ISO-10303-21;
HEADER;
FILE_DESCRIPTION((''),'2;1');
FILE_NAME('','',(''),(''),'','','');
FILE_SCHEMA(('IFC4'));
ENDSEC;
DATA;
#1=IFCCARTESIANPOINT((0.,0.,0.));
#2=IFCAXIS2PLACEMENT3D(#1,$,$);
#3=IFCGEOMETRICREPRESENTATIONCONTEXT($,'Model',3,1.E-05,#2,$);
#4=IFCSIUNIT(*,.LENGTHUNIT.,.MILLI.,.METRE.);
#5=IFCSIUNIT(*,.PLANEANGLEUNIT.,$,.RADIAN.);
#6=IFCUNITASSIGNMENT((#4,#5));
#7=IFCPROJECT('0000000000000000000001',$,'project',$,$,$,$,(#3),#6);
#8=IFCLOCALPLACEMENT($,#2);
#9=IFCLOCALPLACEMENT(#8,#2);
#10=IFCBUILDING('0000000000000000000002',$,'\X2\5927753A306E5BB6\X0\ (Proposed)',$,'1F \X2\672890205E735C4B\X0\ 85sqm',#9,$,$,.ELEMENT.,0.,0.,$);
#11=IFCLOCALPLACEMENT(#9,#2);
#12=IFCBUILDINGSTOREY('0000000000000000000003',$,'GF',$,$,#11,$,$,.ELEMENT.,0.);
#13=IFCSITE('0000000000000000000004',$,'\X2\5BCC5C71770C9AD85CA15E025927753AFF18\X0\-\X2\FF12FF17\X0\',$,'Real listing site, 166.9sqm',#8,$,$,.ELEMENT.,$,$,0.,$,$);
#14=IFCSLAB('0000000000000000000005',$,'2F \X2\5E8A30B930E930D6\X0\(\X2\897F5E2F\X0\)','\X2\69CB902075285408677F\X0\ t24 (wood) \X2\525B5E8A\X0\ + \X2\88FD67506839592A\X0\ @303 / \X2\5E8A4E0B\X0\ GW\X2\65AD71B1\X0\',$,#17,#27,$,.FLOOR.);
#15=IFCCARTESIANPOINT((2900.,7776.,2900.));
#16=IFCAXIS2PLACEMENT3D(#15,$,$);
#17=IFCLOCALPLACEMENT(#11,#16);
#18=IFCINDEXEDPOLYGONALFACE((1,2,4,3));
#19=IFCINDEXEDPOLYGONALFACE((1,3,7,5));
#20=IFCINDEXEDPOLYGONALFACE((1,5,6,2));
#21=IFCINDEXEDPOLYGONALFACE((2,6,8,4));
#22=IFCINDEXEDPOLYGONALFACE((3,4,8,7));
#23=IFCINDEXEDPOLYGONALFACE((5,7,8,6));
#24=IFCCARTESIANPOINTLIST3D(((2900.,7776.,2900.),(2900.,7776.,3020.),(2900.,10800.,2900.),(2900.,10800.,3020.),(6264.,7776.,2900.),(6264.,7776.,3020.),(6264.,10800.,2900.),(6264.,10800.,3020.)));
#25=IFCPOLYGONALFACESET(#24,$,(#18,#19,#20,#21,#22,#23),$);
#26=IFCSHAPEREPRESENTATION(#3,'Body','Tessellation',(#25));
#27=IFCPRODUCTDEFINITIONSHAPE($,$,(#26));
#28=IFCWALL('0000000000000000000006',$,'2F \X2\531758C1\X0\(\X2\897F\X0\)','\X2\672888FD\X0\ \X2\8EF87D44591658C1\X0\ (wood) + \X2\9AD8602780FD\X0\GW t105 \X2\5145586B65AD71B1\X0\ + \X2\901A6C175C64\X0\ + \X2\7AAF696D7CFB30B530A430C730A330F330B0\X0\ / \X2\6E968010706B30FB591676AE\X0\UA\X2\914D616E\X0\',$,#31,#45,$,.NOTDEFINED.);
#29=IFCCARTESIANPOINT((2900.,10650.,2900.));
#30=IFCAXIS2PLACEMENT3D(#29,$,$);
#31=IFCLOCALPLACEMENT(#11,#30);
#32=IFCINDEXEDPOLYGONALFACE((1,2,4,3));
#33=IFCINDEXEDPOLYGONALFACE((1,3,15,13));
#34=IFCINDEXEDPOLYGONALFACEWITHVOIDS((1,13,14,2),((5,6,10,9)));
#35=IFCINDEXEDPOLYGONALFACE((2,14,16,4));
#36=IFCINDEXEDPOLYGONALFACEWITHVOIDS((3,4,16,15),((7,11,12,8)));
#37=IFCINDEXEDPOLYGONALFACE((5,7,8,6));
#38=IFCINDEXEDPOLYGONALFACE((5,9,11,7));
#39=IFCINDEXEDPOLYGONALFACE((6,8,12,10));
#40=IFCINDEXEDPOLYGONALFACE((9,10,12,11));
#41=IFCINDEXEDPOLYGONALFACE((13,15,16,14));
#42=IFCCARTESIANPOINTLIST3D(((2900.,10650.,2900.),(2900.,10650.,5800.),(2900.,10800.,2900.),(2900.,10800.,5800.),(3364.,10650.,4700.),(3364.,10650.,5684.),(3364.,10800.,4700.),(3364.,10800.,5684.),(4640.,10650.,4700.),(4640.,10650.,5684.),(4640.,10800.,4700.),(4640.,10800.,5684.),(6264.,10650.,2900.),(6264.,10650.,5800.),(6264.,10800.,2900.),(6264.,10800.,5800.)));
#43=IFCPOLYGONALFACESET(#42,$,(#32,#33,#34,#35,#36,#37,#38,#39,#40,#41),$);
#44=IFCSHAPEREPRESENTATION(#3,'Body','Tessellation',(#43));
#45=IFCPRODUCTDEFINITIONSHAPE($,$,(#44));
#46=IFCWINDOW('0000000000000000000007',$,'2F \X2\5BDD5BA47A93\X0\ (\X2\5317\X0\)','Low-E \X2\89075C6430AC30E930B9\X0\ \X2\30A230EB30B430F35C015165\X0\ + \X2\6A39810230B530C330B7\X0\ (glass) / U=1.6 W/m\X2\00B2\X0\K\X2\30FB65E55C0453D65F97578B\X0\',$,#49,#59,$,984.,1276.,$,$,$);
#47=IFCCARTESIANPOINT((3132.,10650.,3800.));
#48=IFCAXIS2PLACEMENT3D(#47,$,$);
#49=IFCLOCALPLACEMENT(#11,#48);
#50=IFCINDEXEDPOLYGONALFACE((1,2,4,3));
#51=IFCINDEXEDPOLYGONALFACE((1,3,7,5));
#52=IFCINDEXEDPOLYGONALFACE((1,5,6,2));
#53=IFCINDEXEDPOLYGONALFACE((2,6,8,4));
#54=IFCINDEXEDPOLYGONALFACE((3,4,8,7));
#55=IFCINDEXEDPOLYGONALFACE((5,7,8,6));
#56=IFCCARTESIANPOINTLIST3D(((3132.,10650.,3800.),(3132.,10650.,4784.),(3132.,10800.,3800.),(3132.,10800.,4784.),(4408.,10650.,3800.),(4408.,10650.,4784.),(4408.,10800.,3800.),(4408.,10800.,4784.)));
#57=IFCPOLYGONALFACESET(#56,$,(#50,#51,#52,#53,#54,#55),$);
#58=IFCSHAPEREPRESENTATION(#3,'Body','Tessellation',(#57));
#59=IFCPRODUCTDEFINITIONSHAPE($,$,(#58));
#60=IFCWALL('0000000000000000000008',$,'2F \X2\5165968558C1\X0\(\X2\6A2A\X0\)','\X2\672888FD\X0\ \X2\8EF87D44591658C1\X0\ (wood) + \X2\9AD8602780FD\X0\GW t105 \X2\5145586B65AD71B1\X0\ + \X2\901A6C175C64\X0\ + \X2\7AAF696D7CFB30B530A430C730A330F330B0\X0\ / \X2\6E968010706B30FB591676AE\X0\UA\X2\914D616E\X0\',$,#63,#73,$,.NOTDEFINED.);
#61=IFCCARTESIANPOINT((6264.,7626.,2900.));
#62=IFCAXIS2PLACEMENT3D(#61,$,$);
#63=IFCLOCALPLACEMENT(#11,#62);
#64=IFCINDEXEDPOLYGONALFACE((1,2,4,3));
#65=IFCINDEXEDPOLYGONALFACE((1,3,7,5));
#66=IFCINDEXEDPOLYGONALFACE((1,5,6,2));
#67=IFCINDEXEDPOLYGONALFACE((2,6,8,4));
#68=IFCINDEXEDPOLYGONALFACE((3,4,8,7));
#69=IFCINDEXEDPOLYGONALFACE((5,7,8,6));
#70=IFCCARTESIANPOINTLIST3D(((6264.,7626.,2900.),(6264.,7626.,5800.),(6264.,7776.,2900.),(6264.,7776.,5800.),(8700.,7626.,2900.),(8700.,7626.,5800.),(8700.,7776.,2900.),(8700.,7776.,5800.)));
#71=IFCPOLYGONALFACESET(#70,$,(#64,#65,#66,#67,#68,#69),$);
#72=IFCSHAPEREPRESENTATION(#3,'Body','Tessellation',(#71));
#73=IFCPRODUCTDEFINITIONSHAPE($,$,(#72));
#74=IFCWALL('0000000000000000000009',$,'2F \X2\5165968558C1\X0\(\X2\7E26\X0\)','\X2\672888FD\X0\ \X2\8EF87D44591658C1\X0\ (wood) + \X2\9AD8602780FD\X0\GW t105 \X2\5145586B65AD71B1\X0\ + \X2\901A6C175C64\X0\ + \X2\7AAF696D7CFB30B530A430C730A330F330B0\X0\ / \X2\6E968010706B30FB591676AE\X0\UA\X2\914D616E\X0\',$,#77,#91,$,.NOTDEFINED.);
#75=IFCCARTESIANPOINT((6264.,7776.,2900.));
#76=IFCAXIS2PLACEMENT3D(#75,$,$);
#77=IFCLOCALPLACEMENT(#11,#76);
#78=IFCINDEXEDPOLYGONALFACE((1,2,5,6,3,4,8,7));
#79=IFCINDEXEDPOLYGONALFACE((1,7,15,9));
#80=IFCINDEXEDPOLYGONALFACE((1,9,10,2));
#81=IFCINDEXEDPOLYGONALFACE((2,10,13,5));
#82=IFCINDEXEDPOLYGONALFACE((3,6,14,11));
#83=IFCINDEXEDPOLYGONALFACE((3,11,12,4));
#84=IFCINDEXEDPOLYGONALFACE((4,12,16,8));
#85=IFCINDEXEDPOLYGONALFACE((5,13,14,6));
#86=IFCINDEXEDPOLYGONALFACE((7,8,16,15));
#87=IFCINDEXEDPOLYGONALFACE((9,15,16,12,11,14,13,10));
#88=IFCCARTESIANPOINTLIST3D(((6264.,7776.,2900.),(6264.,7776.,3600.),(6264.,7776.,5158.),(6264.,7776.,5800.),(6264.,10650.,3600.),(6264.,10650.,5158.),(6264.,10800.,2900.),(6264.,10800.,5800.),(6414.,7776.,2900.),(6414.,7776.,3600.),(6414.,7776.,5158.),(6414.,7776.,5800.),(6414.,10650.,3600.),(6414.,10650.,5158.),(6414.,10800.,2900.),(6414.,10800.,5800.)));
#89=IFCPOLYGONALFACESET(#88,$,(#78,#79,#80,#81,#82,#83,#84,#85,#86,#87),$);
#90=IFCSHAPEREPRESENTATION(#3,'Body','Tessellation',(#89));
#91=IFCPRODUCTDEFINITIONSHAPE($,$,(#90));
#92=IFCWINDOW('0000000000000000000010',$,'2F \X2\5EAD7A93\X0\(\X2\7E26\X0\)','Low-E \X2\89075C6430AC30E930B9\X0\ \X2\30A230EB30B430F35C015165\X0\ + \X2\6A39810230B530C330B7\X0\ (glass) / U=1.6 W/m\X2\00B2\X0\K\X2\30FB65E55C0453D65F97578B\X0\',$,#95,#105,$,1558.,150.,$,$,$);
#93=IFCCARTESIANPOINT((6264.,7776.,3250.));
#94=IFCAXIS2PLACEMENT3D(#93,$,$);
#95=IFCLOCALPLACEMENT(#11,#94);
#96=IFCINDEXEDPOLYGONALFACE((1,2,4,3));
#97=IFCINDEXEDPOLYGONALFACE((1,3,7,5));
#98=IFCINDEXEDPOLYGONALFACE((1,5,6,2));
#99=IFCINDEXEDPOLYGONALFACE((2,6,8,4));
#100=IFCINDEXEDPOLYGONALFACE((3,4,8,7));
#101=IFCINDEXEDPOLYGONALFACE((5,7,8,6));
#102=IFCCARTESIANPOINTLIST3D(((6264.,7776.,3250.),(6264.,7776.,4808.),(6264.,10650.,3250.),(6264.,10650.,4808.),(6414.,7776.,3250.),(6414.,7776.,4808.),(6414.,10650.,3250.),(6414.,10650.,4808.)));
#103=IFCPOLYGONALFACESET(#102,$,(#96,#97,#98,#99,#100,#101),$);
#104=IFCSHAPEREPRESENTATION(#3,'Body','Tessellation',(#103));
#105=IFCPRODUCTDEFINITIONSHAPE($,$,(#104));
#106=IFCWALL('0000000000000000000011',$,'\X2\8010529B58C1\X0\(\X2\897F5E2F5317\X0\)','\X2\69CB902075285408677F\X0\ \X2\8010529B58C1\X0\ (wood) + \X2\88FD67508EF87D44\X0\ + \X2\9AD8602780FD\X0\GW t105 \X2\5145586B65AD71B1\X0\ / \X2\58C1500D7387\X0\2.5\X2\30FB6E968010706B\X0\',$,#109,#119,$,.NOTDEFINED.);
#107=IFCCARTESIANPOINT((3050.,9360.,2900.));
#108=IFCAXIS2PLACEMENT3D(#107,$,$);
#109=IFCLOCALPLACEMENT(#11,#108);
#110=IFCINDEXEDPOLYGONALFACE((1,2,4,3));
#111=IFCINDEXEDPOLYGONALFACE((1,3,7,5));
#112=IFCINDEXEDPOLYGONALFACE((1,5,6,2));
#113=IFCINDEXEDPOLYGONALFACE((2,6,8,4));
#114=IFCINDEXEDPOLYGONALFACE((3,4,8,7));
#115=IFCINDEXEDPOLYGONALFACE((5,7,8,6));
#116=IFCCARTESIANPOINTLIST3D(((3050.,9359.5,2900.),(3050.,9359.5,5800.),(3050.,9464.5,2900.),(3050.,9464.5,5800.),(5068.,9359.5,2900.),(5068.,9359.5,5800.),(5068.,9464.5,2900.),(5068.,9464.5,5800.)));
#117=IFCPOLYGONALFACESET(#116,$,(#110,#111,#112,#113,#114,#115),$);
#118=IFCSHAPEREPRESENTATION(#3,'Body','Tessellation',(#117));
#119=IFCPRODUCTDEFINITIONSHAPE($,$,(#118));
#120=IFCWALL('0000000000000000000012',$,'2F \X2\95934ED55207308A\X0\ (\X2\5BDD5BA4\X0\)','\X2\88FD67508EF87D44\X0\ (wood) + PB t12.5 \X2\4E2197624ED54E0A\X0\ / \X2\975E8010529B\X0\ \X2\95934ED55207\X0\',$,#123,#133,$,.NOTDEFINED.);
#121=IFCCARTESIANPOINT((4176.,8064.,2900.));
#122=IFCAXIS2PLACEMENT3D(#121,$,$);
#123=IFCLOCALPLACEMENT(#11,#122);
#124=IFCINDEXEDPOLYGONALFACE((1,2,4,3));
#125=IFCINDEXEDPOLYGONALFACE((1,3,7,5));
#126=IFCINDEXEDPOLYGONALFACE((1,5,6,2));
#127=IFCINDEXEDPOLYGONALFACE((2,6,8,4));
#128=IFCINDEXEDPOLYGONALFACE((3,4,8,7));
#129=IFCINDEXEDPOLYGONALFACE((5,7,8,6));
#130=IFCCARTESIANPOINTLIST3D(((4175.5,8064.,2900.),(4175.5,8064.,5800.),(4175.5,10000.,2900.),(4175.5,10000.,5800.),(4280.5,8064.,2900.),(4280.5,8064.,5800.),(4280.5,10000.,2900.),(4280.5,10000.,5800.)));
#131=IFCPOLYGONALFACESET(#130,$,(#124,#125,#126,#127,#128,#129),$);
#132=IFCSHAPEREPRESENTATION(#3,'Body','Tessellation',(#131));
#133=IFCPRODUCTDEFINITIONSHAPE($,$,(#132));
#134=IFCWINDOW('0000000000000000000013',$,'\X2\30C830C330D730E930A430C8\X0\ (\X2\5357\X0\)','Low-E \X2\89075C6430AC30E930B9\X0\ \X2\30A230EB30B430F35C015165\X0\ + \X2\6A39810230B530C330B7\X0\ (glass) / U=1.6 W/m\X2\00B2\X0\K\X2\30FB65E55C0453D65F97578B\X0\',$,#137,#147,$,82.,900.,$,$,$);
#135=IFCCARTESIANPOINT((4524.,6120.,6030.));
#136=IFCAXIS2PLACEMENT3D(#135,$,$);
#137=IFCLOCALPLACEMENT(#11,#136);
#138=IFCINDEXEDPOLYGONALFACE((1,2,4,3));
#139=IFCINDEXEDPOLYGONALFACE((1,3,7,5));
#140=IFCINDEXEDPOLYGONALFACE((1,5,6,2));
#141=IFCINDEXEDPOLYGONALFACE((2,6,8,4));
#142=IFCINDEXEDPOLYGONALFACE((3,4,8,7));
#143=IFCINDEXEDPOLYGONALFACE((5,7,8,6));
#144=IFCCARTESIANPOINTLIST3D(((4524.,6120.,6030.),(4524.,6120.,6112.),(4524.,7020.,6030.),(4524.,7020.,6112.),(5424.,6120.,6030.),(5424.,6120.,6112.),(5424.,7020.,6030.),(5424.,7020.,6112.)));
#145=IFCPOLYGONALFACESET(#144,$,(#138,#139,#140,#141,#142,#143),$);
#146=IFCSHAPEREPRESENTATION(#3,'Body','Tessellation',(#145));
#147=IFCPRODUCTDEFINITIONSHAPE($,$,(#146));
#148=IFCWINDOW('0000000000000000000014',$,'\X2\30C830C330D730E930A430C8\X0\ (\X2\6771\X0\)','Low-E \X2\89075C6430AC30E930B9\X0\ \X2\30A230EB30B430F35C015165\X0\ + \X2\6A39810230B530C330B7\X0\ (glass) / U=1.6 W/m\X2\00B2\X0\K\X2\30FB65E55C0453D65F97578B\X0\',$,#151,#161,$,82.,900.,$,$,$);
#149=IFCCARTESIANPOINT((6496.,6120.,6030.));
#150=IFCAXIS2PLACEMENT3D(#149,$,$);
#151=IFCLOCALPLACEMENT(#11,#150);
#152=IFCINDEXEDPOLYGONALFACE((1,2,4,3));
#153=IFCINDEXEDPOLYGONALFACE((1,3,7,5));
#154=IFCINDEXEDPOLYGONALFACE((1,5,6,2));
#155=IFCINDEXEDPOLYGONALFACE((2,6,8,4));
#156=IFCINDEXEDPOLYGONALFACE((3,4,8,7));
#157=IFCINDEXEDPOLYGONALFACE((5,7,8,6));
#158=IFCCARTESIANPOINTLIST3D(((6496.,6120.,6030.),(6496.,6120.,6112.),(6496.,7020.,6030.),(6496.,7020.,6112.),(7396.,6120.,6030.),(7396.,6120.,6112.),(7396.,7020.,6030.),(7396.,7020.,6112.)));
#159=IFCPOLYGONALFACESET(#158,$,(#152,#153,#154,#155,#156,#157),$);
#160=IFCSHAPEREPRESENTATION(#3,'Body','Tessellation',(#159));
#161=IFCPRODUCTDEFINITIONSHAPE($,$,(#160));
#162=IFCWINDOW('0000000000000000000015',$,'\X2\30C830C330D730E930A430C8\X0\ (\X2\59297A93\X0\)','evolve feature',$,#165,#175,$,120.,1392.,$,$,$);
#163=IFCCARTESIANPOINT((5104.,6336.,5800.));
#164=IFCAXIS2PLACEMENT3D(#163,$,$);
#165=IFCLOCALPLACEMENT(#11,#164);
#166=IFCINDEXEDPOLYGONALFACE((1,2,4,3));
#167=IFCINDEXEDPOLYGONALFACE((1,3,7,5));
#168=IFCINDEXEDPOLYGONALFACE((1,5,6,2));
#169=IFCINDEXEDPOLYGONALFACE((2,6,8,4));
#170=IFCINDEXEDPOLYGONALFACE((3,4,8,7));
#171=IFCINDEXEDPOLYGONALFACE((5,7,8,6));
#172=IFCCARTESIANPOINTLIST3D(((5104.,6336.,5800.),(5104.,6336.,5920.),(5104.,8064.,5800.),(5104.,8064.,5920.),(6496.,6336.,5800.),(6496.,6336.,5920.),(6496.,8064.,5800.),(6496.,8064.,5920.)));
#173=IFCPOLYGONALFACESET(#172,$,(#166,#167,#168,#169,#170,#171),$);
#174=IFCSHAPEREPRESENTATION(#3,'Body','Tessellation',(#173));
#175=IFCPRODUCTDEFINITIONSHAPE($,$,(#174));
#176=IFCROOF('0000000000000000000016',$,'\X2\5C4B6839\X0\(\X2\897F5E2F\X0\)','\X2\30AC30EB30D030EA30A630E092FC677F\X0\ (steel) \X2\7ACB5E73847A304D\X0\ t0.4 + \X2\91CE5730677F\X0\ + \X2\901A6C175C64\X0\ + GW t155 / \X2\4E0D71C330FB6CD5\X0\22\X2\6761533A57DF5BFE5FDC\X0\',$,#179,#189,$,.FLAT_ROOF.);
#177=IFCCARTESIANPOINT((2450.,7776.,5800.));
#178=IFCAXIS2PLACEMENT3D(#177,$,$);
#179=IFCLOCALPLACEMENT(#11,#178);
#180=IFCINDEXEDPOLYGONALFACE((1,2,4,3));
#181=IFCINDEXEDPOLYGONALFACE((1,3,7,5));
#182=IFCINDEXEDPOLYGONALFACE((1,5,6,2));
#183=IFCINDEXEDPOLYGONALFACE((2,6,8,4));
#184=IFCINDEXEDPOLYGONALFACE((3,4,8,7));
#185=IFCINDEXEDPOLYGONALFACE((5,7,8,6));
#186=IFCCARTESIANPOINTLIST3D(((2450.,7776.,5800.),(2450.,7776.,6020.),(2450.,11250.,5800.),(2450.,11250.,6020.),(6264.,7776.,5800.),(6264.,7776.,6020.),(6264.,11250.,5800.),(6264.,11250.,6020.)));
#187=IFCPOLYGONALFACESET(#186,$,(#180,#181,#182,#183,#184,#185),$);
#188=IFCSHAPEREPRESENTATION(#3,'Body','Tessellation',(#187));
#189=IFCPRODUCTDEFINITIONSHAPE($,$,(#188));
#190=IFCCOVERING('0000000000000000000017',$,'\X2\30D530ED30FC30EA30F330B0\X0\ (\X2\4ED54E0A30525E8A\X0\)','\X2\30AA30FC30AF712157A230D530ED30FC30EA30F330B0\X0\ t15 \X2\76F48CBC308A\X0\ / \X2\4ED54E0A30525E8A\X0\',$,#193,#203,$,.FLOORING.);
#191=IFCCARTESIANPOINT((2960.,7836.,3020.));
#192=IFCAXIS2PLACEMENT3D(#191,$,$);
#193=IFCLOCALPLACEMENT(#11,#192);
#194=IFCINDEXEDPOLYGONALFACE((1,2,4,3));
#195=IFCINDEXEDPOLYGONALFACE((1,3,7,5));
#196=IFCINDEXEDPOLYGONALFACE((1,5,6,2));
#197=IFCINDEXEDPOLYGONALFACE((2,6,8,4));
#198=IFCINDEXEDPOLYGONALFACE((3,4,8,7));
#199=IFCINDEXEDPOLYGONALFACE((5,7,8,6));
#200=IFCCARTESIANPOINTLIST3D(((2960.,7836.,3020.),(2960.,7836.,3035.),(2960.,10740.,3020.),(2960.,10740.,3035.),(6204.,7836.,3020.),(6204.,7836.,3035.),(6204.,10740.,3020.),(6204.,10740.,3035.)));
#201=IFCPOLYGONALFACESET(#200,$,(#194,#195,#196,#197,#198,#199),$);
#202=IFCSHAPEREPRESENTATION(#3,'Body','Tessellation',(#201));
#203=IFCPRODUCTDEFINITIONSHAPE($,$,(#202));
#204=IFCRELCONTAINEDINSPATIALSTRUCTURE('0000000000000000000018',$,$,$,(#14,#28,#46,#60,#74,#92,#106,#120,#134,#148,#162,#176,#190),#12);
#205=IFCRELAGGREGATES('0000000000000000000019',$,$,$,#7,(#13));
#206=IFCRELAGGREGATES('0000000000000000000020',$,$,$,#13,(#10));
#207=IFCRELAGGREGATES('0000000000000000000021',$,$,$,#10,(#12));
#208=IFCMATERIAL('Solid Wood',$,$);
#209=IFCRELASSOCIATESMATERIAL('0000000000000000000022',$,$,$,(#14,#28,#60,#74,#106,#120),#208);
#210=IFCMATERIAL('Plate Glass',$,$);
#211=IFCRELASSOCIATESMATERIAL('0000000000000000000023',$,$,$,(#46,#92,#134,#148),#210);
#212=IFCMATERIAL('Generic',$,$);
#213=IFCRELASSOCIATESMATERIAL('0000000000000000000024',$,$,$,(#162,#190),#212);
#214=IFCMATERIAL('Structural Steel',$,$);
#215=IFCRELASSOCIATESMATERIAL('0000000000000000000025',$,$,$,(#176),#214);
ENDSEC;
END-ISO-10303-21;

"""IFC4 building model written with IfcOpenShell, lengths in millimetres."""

from ifc_helpers import new_model, si_unit, frame, frame_2d, origin, place, context, project, spatial, rectangle, extrude, material, element, fill, save


model = new_model("IFC4")

# Units and contexts
model_context = context("Model", 3, precision=1e-05, world=origin())
ifc_project = project(units=[si_unit("LENGTHUNIT", "METRE", prefix="MILLI"), si_unit("PLANEANGLEUNIT", "RADIAN")], contexts=[model_context])

# Site, building, storey
site_placement = place(None, origin())
site = spatial("IfcSite", under=ifc_project, at=site_placement, Name="富山県高岡市大町８-２７", ObjectType="Real listing site, 166.9sqm", CompositionType="ELEMENT", RefElevation=0.0)
building_placement = place(site_placement, origin())
building = spatial("IfcBuilding", under=site, at=building_placement, Name="大町の家 (Proposed)", ObjectType="1F 木造平屋 85sqm", CompositionType="ELEMENT", ElevationOfRefHeight=0.0, ElevationOfTerrain=0.0)
storey_placement = place(building_placement, origin())
storey = spatial("IfcBuildingStorey", under=building, at=storey_placement, Name="GF", CompositionType="ELEMENT", Elevation=0.0)

# Slab
ifc_material_1 = material(Name="Solid Wood")
slab_placement = place(storey_placement, frame((2900.0, 7776.0, 2900.0)))
element("IfcSlab", 1, at=slab_placement, inside=storey, material=ifc_material_1, Name="2F 床スラブ(西帯)", Description="構造用合板 t24 (wood) 剛床 + 製材根太 @303 / 床下 GW断熱", PredefinedType="FLOOR", context=model_context, shape_type="SweptSolid", body=[
    extrude(rectangle(XDim=3364.0, YDim=3024.0, at=frame_2d((1682.0, 1512.0))), frame((2900.0, 7776.0, 2900.0)), (0.0, 0.0, 1.0), 120.0),
])

# Wall, opening, window
wall_1_placement = place(storey_placement, frame((2900.0, 10650.0, 2900.0)))
wall_1 = element("IfcWall", 2, at=wall_1_placement, inside=storey, material=ifc_material_1, Name="2F 北壁(西)", Description="木製 軸組外壁 (wood) + 高性能GW t105 充填断熱 + 通気層 + 窯業系サイディング / 準耐火・外皮UA配慮", PredefinedType="NOTDEFINED", context=model_context, shape_type="SweptSolid", body=[
    extrude(rectangle(XDim=3364.0, YDim=150.0, at=frame_2d((1682.0, 75.0))), frame((2900.0, 10650.0, 2900.0)), (0.0, 0.0, 1.0), 2900.0),
])
opening_1_placement = place(storey_placement, frame((3132.0, 10650.0, 3800.0)))
opening_1 = element("IfcOpeningElement", 3, at=opening_1_placement, cuts=wall_1, PredefinedType="NOTDEFINED", context=model_context, shape_type="SweptSolid", body=[
    extrude(rectangle(XDim=1276.0, YDim=150.0, at=frame_2d((638.0, 75.0))), frame((3132.0, 10650.0, 3800.0)), (0.0, 0.0, 1.0), 984.0),
])
ifc_material_2 = material(Name="Plate Glass")
window_1_placement = place(storey_placement, frame((3132.0, 10650.0, 3800.0)))
window_1 = element("IfcWindow", 4, at=window_1_placement, inside=storey, material=ifc_material_2, Name="2F 寝室窓 (北)", Description="Low-E 複層ガラス アルゴン封入 + 樹脂サッシ (glass) / U=1.6 W/m²K・日射取得型", OverallHeight=984.0, OverallWidth=1276.0, context=model_context, shape_type="SweptSolid", body=[
    extrude(rectangle(XDim=1276.0, YDim=150.0, at=frame_2d((638.0, 75.0))), frame((3132.0, 10650.0, 3800.0)), (0.0, 0.0, 1.0), 984.0),
])
fill(opening_1, window_1)

# Wall
wall_2_placement = place(storey_placement, frame((6264.0, 7626.0, 2900.0)))
element("IfcWall", 5, at=wall_2_placement, inside=storey, material=ifc_material_1, Name="2F 入隅壁(横)", Description="木製 軸組外壁 (wood) + 高性能GW t105 充填断熱 + 通気層 + 窯業系サイディング / 準耐火・外皮UA配慮", PredefinedType="NOTDEFINED", context=model_context, shape_type="SweptSolid", body=[
    extrude(rectangle(XDim=2436.0, YDim=150.0, at=frame_2d((1218.0, 75.0))), frame((6264.0, 7626.0, 2900.0)), (0.0, 0.0, 1.0), 2900.0),
])

# Wall, opening, window
wall_3_placement = place(storey_placement, frame((6264.0, 7776.0, 2900.0)))
wall_3 = element("IfcWall", 6, at=wall_3_placement, inside=storey, material=ifc_material_1, Name="2F 入隅壁(縦)", Description="木製 軸組外壁 (wood) + 高性能GW t105 充填断熱 + 通気層 + 窯業系サイディング / 準耐火・外皮UA配慮", PredefinedType="NOTDEFINED", context=model_context, shape_type="SweptSolid", body=[
    extrude(rectangle(XDim=150.0, YDim=3024.0, at=frame_2d((75.0, 1512.0))), frame((6264.0, 7776.0, 2900.0)), (0.0, 0.0, 1.0), 2900.0),
])
opening_2_placement = place(storey_placement, frame((6264.0, 7776.0, 3250.0)))
opening_2 = element("IfcOpeningElement", 7, at=opening_2_placement, cuts=wall_3, PredefinedType="NOTDEFINED", context=model_context, shape_type="SweptSolid", body=[
    extrude(rectangle(XDim=150.0, YDim=2874.0, at=frame_2d((75.0, 1437.0))), frame((6264.0, 7776.0, 3250.0)), (0.0, 0.0, 1.0), 1558.0),
])
window_2_placement = place(storey_placement, frame((6264.0, 7776.0, 3250.0)))
window_2 = element("IfcWindow", 8, at=window_2_placement, inside=storey, material=ifc_material_2, Name="2F 庭窓(縦)", Description="Low-E 複層ガラス アルゴン封入 + 樹脂サッシ (glass) / U=1.6 W/m²K・日射取得型", OverallHeight=1558.0, OverallWidth=150.0, context=model_context, shape_type="SweptSolid", body=[
    extrude(rectangle(XDim=150.0, YDim=2874.0, at=frame_2d((75.0, 1437.0))), frame((6264.0, 7776.0, 3250.0)), (0.0, 0.0, 1.0), 1558.0),
])
fill(opening_2, window_2)

# Walls
wall_4_placement = place(storey_placement, frame((3050.0, 9360.0, 2900.0)))
element("IfcWall", 9, at=wall_4_placement, inside=storey, material=ifc_material_1, Name="耐力壁(西帯北)", Description="構造用合板 耐力壁 (wood) + 製材軸組 + 高性能GW t105 充填断熱 / 壁倍率2.5・準耐火", PredefinedType="NOTDEFINED", context=model_context, shape_type="SweptSolid", body=[
    extrude(rectangle(XDim=2018.0, YDim=105.0, at=frame_2d((1009.0, 52.0))), frame((3050.0, 9360.0, 2900.0)), (0.0, 0.0, 1.0), 2900.0),
])
wall_5_placement = place(storey_placement, frame((4176.0, 8064.0, 2900.0)))
element("IfcWall", 10, at=wall_5_placement, inside=storey, material=ifc_material_1, Name="2F 間仕切り (寝室)", Description="製材軸組 (wood) + PB t12.5 両面仕上 / 非耐力 間仕切", PredefinedType="NOTDEFINED", context=model_context, shape_type="SweptSolid", body=[
    extrude(rectangle(XDim=105.0, YDim=1936.0, at=frame_2d((52.0, 968.0))), frame((4176.0, 8064.0, 2900.0)), (0.0, 0.0, 1.0), 2900.0),
])

# Windows
window_3_placement = place(storey_placement, frame((4524.0, 6120.0, 6030.0)))
element("IfcWindow", 11, at=window_3_placement, inside=storey, material=ifc_material_2, Name="トップライト (南)", Description="Low-E 複層ガラス アルゴン封入 + 樹脂サッシ (glass) / U=1.6 W/m²K・日射取得型", OverallHeight=82.0, OverallWidth=900.0, context=model_context, shape_type="SweptSolid", body=[
    extrude(rectangle(XDim=900.0, YDim=900.0, at=frame_2d((450.0, 450.0))), frame((4524.0, 6120.0, 6030.0)), (0.0, 0.0, 1.0), 82.0),
])
window_4_placement = place(storey_placement, frame((6496.0, 6120.0, 6030.0)))
element("IfcWindow", 12, at=window_4_placement, inside=storey, material=ifc_material_2, Name="トップライト (東)", Description="Low-E 複層ガラス アルゴン封入 + 樹脂サッシ (glass) / U=1.6 W/m²K・日射取得型", OverallHeight=82.0, OverallWidth=900.0, context=model_context, shape_type="SweptSolid", body=[
    extrude(rectangle(XDim=900.0, YDim=900.0, at=frame_2d((450.0, 450.0))), frame((6496.0, 6120.0, 6030.0)), (0.0, 0.0, 1.0), 82.0),
])
ifc_material_3 = material(Name="Generic")
window_5_placement = place(storey_placement, frame((5104.0, 6336.0, 5800.0)))
element("IfcWindow", 13, at=window_5_placement, inside=storey, material=ifc_material_3, Name="トップライト (天窓)", Description="evolve feature", OverallHeight=120.0, OverallWidth=1392.0, context=model_context, shape_type="SweptSolid", body=[
    extrude(rectangle(XDim=1392.0, YDim=1728.0, at=frame_2d((696.0, 864.0))), frame((5104.0, 6336.0, 5800.0)), (0.0, 0.0, 1.0), 120.0),
])

# Roof
ifc_material_4 = material(Name="Structural Steel")
for number, where, name in (
    (14, (2450.0, 7776.0, 5800.0), "屋根(西帯)"),
):
    element("IfcRoof", number, at=place(storey_placement, frame(where)), inside=storey, material=ifc_material_4, Name=name, Description="ガルバリウム鋼板 (steel) 立平葺き t0.4 + 野地板 + 通気層 + GW t155 / 不燃・法22条区域対応", PredefinedType="FLAT_ROOF", context=model_context, shape_type="SweptSolid", body=[
        extrude(rectangle(XDim=3814.0, YDim=3474.0, at=frame_2d((1907.0, 1737.0))), frame((2450.0, 7776.0, 5800.0)), (0.0, 0.0, 1.0), 220.0),
    ])

# Covering
covering_placement = place(storey_placement, frame((2960.0, 7836.0, 3020.0)))
element("IfcCovering", 15, at=covering_placement, inside=storey, material=ifc_material_3, Name="フローリング (仕上げ床)", Description="オーク無垢フローリング t15 直貼り / 仕上げ床", PredefinedType="FLOORING", context=model_context, shape_type="SweptSolid", body=[
    extrude(rectangle(XDim=3244.0, YDim=2904.0, at=frame_2d((1622.0, 1452.0))), frame((2960.0, 7836.0, 3020.0)), (0.0, 0.0, 1.0), 15.0),
])

save(model, "model.ifc")
